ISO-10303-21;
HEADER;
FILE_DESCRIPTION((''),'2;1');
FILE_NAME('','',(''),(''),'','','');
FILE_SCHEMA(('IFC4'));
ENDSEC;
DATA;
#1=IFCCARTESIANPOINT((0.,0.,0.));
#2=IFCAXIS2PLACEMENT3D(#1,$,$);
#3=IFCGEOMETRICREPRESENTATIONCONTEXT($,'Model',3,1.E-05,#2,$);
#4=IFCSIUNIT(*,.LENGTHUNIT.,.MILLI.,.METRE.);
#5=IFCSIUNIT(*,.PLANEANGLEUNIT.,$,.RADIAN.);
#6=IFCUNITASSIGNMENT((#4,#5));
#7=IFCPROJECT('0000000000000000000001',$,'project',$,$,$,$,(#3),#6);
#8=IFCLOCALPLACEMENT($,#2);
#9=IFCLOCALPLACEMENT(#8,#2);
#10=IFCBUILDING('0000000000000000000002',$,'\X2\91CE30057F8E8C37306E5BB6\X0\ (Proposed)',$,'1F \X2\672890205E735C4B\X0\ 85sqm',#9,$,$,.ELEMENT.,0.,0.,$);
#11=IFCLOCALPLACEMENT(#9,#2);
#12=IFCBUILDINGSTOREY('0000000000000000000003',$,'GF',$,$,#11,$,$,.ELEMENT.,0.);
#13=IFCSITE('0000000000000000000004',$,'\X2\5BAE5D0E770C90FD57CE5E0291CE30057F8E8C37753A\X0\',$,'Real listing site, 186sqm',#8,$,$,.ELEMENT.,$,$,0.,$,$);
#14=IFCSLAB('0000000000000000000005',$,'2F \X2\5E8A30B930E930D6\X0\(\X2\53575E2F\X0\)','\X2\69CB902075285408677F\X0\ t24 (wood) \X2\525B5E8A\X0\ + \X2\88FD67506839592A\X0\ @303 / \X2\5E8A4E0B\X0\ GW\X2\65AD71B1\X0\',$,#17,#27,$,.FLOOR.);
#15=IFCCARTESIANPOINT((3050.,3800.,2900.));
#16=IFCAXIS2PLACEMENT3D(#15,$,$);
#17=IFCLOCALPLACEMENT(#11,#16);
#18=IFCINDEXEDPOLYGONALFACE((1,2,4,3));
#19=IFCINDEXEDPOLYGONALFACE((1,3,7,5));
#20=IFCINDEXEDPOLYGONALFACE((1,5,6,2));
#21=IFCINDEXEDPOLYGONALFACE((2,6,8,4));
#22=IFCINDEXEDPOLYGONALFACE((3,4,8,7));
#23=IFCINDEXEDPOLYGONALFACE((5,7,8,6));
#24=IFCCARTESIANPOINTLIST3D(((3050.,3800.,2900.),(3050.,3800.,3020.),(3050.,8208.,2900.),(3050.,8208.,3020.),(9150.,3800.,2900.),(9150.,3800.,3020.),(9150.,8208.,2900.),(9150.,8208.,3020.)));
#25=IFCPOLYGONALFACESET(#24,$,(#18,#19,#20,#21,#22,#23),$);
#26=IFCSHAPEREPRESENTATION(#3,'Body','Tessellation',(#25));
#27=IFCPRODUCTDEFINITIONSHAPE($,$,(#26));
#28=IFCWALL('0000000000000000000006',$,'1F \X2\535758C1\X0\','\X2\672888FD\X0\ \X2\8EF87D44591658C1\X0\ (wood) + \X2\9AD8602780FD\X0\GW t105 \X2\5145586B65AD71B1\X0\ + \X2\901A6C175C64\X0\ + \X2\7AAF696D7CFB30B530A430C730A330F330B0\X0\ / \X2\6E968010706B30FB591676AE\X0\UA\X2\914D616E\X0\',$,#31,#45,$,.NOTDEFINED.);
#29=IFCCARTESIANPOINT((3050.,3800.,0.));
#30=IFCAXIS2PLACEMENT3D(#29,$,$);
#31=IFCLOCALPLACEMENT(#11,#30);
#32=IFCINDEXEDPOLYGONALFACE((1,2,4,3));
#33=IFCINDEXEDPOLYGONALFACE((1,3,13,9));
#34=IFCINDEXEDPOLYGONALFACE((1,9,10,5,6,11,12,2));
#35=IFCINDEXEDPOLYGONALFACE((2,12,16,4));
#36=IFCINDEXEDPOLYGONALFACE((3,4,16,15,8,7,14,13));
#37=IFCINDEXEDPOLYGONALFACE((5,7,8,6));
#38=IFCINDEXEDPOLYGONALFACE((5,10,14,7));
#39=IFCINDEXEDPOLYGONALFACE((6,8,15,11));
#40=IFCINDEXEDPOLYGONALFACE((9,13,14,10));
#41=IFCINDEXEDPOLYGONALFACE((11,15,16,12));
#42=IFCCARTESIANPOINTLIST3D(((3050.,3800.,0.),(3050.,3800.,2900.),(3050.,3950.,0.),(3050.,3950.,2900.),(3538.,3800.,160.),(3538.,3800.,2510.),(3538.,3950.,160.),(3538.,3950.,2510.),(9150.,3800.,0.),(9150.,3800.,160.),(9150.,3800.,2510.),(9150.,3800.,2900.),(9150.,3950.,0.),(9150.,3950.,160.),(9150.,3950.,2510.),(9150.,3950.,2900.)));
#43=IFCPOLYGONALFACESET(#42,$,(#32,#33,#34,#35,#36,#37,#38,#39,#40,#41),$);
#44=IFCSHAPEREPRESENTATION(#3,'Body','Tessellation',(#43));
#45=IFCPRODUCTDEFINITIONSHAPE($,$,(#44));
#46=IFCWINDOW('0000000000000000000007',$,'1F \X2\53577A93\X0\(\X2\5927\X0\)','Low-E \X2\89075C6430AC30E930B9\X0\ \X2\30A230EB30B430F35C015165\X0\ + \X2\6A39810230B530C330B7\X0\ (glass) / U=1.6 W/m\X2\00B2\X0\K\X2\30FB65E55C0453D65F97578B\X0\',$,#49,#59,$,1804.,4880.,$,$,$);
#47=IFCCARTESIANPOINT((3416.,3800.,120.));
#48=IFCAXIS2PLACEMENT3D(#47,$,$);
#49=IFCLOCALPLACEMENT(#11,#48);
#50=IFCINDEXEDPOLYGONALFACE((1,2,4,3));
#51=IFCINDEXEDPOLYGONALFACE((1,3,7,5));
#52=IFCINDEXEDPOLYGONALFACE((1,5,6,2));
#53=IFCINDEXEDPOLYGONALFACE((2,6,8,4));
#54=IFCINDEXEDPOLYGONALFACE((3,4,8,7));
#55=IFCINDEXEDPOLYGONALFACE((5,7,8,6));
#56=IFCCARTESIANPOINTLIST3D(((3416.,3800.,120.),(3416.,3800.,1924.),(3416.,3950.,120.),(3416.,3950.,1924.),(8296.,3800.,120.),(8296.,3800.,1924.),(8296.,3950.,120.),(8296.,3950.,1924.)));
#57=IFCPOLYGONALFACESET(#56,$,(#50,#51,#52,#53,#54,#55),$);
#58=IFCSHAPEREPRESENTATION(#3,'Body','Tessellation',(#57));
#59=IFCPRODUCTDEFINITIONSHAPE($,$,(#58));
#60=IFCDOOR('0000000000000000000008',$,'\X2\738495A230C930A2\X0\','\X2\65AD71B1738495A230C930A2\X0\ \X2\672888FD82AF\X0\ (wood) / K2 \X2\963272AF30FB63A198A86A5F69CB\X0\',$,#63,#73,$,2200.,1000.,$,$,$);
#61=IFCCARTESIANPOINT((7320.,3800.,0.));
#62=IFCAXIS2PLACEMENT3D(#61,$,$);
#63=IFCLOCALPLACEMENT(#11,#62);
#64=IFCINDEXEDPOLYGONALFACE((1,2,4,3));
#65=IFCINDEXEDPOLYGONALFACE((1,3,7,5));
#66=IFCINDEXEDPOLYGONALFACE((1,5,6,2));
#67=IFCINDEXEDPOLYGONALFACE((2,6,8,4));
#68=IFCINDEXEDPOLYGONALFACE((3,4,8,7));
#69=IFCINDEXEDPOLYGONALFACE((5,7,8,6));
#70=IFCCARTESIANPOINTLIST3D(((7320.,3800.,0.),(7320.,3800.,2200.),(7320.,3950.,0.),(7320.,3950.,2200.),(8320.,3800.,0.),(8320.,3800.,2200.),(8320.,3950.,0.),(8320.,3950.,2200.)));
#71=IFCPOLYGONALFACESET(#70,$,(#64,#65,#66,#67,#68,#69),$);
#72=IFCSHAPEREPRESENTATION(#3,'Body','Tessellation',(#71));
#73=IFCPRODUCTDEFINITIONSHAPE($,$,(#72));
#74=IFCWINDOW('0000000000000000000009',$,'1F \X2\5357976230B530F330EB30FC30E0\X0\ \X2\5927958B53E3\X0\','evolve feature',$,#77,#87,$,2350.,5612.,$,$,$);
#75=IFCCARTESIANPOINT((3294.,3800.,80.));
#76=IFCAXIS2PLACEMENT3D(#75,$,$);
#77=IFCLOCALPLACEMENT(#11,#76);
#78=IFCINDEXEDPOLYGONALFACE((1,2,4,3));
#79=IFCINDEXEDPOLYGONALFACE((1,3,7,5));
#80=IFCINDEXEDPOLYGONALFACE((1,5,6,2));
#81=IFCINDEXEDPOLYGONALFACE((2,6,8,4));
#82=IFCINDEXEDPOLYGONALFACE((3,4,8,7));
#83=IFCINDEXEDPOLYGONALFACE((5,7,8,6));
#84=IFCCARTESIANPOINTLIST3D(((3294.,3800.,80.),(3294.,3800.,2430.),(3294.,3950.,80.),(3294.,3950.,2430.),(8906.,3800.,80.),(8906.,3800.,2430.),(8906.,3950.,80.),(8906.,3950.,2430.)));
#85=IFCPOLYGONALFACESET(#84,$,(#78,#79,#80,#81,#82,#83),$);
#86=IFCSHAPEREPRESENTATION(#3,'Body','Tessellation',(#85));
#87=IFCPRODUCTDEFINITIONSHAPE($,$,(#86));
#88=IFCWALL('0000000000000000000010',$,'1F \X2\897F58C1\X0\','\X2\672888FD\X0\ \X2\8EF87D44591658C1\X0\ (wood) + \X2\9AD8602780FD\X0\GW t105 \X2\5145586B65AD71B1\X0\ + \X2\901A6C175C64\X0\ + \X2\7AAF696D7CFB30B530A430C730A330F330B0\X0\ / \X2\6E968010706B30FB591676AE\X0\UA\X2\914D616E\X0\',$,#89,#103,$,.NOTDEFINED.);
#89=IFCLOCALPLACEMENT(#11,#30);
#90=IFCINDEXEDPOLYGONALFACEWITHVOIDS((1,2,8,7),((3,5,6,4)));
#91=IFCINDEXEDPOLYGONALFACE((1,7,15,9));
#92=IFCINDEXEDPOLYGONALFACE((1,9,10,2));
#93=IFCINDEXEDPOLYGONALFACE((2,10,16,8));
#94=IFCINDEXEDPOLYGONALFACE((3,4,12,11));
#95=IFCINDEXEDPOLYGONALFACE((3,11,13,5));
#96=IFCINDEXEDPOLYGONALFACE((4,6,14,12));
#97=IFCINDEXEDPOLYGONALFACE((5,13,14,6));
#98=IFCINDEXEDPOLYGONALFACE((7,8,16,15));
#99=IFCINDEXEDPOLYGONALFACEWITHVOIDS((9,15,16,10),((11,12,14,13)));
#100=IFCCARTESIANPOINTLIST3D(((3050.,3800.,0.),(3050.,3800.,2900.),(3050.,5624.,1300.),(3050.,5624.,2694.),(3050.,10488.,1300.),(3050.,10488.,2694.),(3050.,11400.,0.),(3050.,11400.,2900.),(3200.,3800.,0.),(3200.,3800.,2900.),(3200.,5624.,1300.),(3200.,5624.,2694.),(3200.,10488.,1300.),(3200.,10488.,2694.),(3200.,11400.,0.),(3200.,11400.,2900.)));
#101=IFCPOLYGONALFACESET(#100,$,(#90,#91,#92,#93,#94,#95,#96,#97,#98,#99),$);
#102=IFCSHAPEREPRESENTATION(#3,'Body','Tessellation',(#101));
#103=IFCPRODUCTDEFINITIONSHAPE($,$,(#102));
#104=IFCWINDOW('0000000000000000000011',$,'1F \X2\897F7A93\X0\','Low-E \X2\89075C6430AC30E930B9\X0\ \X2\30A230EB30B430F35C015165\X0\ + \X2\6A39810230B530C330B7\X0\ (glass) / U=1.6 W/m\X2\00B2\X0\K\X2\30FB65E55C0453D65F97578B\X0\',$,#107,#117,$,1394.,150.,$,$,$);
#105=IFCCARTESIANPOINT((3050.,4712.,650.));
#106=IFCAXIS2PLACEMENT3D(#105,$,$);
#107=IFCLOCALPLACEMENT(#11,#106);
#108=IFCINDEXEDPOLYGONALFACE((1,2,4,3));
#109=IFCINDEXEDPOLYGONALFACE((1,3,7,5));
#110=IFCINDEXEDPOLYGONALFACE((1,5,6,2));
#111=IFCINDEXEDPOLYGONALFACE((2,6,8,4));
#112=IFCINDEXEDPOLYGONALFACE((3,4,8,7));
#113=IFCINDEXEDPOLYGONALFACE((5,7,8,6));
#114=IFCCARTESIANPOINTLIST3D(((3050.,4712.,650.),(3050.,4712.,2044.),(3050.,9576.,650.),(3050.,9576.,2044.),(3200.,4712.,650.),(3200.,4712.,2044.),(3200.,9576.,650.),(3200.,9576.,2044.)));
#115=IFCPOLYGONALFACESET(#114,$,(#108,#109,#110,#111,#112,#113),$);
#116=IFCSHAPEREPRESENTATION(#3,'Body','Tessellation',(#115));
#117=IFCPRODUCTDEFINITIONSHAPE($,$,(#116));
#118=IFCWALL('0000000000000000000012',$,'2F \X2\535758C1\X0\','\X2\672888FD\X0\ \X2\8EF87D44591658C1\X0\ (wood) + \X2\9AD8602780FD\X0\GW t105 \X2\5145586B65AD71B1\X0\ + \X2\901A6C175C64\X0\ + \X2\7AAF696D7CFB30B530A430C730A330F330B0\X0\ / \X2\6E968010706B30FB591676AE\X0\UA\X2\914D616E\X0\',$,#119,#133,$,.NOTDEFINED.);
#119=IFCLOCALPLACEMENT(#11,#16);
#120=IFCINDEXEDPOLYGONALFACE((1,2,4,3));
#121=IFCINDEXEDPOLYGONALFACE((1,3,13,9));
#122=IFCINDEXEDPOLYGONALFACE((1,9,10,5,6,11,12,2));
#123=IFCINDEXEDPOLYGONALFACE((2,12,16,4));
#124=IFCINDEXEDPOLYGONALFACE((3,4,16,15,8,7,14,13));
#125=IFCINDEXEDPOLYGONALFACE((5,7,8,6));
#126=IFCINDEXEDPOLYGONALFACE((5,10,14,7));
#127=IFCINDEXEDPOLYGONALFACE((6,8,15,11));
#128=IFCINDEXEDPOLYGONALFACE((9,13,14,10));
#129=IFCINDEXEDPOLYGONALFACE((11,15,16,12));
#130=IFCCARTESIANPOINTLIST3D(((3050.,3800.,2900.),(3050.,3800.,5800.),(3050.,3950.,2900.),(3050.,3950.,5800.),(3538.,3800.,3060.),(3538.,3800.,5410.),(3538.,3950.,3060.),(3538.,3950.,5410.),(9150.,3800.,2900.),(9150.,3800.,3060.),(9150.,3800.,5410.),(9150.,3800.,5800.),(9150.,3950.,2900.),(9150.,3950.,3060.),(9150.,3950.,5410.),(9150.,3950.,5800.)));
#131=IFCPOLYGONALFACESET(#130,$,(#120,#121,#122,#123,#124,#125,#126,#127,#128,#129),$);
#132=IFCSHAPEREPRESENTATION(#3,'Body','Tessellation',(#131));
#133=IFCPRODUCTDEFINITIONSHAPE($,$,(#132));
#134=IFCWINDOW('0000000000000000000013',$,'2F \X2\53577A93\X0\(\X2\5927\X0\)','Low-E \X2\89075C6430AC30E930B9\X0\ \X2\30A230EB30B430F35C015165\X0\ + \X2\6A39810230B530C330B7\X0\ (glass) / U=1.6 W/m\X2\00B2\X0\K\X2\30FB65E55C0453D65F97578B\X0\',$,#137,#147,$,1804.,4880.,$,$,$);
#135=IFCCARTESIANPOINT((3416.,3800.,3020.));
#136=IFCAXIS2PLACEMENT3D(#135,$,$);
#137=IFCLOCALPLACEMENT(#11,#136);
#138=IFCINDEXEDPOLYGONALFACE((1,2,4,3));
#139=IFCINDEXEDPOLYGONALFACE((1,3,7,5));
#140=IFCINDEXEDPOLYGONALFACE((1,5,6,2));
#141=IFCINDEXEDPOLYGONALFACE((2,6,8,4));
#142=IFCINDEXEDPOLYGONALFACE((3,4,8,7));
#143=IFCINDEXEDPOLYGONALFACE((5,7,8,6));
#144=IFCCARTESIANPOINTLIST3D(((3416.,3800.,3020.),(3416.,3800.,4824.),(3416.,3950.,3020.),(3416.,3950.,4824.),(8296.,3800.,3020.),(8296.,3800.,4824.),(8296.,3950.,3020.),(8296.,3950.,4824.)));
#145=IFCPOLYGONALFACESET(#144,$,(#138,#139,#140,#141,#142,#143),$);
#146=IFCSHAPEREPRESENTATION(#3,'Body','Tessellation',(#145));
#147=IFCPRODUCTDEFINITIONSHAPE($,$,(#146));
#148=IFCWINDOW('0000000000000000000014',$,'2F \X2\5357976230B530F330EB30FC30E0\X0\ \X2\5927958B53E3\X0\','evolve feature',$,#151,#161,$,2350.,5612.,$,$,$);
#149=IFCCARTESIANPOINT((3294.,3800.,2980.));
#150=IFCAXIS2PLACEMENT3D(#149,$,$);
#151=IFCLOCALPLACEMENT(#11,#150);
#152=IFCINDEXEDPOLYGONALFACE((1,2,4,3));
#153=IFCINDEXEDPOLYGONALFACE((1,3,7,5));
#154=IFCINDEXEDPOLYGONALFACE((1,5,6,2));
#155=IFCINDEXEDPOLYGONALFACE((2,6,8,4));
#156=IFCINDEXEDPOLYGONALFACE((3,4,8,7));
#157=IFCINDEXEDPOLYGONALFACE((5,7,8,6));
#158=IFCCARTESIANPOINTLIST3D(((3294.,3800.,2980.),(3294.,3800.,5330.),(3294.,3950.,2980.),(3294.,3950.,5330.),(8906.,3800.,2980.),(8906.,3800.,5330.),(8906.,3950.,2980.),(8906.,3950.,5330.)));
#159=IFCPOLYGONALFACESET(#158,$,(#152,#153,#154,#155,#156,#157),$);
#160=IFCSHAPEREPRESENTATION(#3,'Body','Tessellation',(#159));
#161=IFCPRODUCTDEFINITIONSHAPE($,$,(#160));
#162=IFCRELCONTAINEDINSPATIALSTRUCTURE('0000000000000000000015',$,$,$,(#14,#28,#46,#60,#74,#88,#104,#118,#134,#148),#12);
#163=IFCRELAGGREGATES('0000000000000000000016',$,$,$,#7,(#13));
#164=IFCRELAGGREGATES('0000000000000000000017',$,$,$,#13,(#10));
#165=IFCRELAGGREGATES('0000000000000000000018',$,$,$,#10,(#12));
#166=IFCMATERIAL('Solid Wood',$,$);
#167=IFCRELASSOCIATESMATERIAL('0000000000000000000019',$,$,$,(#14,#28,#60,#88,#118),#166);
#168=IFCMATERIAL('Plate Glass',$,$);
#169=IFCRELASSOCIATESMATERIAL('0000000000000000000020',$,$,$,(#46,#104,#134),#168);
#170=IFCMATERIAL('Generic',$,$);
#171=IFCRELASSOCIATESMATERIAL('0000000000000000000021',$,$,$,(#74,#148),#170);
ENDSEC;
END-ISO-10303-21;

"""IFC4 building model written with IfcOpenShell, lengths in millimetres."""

from ifc_helpers import new_model, si_unit, frame, frame_2d, origin, place, context, project, spatial, rectangle, extrude, material, element, fill, save


model = new_model("IFC4")

# Units and contexts
model_context = context("Model", 3, precision=1e-05, world=origin())
ifc_project = project(units=[si_unit("LENGTHUNIT", "METRE", prefix="MILLI"), si_unit("PLANEANGLEUNIT", "RADIAN")], contexts=[model_context])

# Site, building, storey
site_placement = place(None, origin())
site = spatial("IfcSite", under=ifc_project, at=site_placement, Name="宮崎県都城市野々美谷町", ObjectType="Real listing site, 186sqm", CompositionType="ELEMENT", RefElevation=0.0)
building_placement = place(site_placement, origin())
building = spatial("IfcBuilding", under=site, at=building_placement, Name="野々美谷の家 (Proposed)", ObjectType="1F 木造平屋 85sqm", CompositionType="ELEMENT", ElevationOfRefHeight=0.0, ElevationOfTerrain=0.0)
storey_placement = place(building_placement, origin())
storey = spatial("IfcBuildingStorey", under=building, at=storey_placement, Name="GF", CompositionType="ELEMENT", Elevation=0.0)

# Slab
ifc_material_1 = material(Name="Solid Wood")
slab_1_placement = place(storey_placement, frame((3050.0, 3800.0, 2900.0)))
element("IfcSlab", 1, at=slab_1_placement, inside=storey, material=ifc_material_1, Name="2F 床スラブ(南帯)", Description="構造用合板 t24 (wood) 剛床 + 製材根太 @303 / 床下 GW断熱", PredefinedType="FLOOR", context=model_context, shape_type="SweptSolid", body=[
    extrude(rectangle(XDim=6100.0, YDim=4408.0, at=frame_2d((3050.0, 2204.0))), frame((3050.0, 3800.0, 2900.0)), (0.0, 0.0, 1.0), 120.0),
])
ifc_material_2 = material(Name="Generic")

# Wall, openings, windows, door
wall_1_placement = place(storey_placement, frame((3050.0, 3800.0, 0.0)))
wall_1 = element("IfcWall", 2, at=wall_1_placement, inside=storey, material=ifc_material_1, Name="1F 南壁", Description="木製 軸組外壁 (wood) + 高性能GW t105 充填断熱 + 通気層 + 窯業系サイディング / 準耐火・外皮UA配慮", PredefinedType="NOTDEFINED", context=model_context, shape_type="SweptSolid", body=[
    extrude(rectangle(XDim=6100.0, YDim=150.0, at=frame_2d((3050.0, 75.0))), frame((3050.0, 3800.0, 0.0)), (0.0, 0.0, 1.0), 2900.0),
])
opening_1_placement = place(storey_placement, frame((3416.0, 3800.0, 120.0)))
opening_1 = element("IfcOpeningElement", 3, at=opening_1_placement, cuts=wall_1, PredefinedType="NOTDEFINED", context=model_context, shape_type="SweptSolid", body=[
    extrude(rectangle(XDim=4880.0, YDim=150.0, at=frame_2d((2440.0, 75.0))), frame((3416.0, 3800.0, 120.0)), (0.0, 0.0, 1.0), 1804.0),
])
opening_2_placement = place(storey_placement, frame((7320.0, 3800.0, 0.0)))
opening_2 = element("IfcOpeningElement", 4, at=opening_2_placement, cuts=wall_1, PredefinedType="NOTDEFINED", context=model_context, shape_type="SweptSolid", body=[
    extrude(rectangle(XDim=1000.0, YDim=150.0, at=frame_2d((500.0, 75.0))), frame((7320.0, 3800.0, 0.0)), (0.0, 0.0, 1.0), 2200.0),
])
opening_3_placement = place(storey_placement, frame((3294.0, 3800.0, 80.0)))
opening_3 = element("IfcOpeningElement", 5, at=opening_3_placement, cuts=wall_1, PredefinedType="NOTDEFINED", context=model_context, shape_type="SweptSolid", body=[
    extrude(rectangle(XDim=5612.0, YDim=150.0, at=frame_2d((2806.0, 75.0))), frame((3294.0, 3800.0, 80.0)), (0.0, 0.0, 1.0), 2350.0),
])
ifc_material_3 = material(Name="Plate Glass")
window_1_placement = place(storey_placement, frame((3416.0, 3800.0, 120.0)))
window_1 = element("IfcWindow", 6, at=window_1_placement, inside=storey, material=ifc_material_3, Name="1F 南窓(大)", Description="Low-E 複層ガラス アルゴン封入 + 樹脂サッシ (glass) / U=1.6 W/m²K・日射取得型", OverallHeight=1804.0, OverallWidth=4880.0, context=model_context, shape_type="SweptSolid", body=[
    extrude(rectangle(XDim=4880.0, YDim=150.0, at=frame_2d((2440.0, 75.0))), frame((3416.0, 3800.0, 120.0)), (0.0, 0.0, 1.0), 1804.0),
])
fill(opening_1, window_1)
door_placement = place(storey_placement, frame((7320.0, 3800.0, 0.0)))
door = element("IfcDoor", 7, at=door_placement, inside=storey, material=ifc_material_1, Name="玄関ドア", Description="断熱玄関ドア 木製芯 (wood) / K2 防犯・採風機構", OverallHeight=2200.0, OverallWidth=1000.0, context=model_context, shape_type="SweptSolid", body=[
    extrude(rectangle(XDim=1000.0, YDim=150.0, at=frame_2d((500.0, 75.0))), frame((7320.0, 3800.0, 0.0)), (0.0, 0.0, 1.0), 2200.0),
])
fill(opening_2, door)
window_2_placement = place(storey_placement, frame((3294.0, 3800.0, 80.0)))
window_2 = element("IfcWindow", 8, at=window_2_placement, inside=storey, material=ifc_material_2, Name="1F 南面サンルーム 大開口", Description="evolve feature", OverallHeight=2350.0, OverallWidth=5612.0, context=model_context, shape_type="SweptSolid", body=[
    extrude(rectangle(XDim=5612.0, YDim=150.0, at=frame_2d((2806.0, 75.0))), frame((3294.0, 3800.0, 80.0)), (0.0, 0.0, 1.0), 2350.0),
])
fill(opening_3, window_2)

# Wall, opening, window
wall_2_placement = place(storey_placement, frame((3050.0, 3800.0, 0.0)))
wall_2 = element("IfcWall", 9, at=wall_2_placement, inside=storey, material=ifc_material_1, Name="1F 西壁", Description="木製 軸組外壁 (wood) + 高性能GW t105 充填断熱 + 通気層 + 窯業系サイディング / 準耐火・外皮UA配慮", PredefinedType="NOTDEFINED", context=model_context, shape_type="SweptSolid", body=[
    extrude(rectangle(XDim=150.0, YDim=7600.0, at=frame_2d((75.0, 3800.0))), frame((3050.0, 3800.0, 0.0)), (0.0, 0.0, 1.0), 2900.0),
])
opening_4_placement = place(storey_placement, frame((3050.0, 4712.0, 650.0)))
opening_4 = element("IfcOpeningElement", 10, at=opening_4_placement, cuts=wall_2, PredefinedType="NOTDEFINED", context=model_context, shape_type="SweptSolid", body=[
    extrude(rectangle(XDim=150.0, YDim=4864.0, at=frame_2d((75.0, 2432.0))), frame((3050.0, 4712.0, 650.0)), (0.0, 0.0, 1.0), 1394.0),
])
window_3_placement = place(storey_placement, frame((3050.0, 4712.0, 650.0)))
window_3 = element("IfcWindow", 11, at=window_3_placement, inside=storey, material=ifc_material_3, Name="1F 西窓", Description="Low-E 複層ガラス アルゴン封入 + 樹脂サッシ (glass) / U=1.6 W/m²K・日射取得型", OverallHeight=1394.0, OverallWidth=150.0, context=model_context, shape_type="SweptSolid", body=[
    extrude(rectangle(XDim=150.0, YDim=4864.0, at=frame_2d((75.0, 2432.0))), frame((3050.0, 4712.0, 650.0)), (0.0, 0.0, 1.0), 1394.0),
])
fill(opening_4, window_3)

# Wall, openings, windows
wall_3_placement = place(storey_placement, frame((3050.0, 3800.0, 2900.0)))
wall_3 = element("IfcWall", 12, at=wall_3_placement, inside=storey, material=ifc_material_1, Name="2F 南壁", Description="木製 軸組外壁 (wood) + 高性能GW t105 充填断熱 + 通気層 + 窯業系サイディング / 準耐火・外皮UA配慮", PredefinedType="NOTDEFINED", context=model_context, shape_type="SweptSolid", body=[
    extrude(rectangle(XDim=6100.0, YDim=150.0, at=frame_2d((3050.0, 75.0))), frame((3050.0, 3800.0, 2900.0)), (0.0, 0.0, 1.0), 2900.0),
])
opening_5_placement = place(storey_placement, frame((3416.0, 3800.0, 3020.0)))
opening_5 = element("IfcOpeningElement", 13, at=opening_5_placement, cuts=wall_3, PredefinedType="NOTDEFINED", context=model_context, shape_type="SweptSolid", body=[
    extrude(rectangle(XDim=4880.0, YDim=150.0, at=frame_2d((2440.0, 75.0))), frame((3416.0, 3800.0, 3020.0)), (0.0, 0.0, 1.0), 1804.0),
])
opening_6_placement = place(storey_placement, frame((3294.0, 3800.0, 2980.0)))
opening_6 = element("IfcOpeningElement", 14, at=opening_6_placement, cuts=wall_3, PredefinedType="NOTDEFINED", context=model_context, shape_type="SweptSolid", body=[
    extrude(rectangle(XDim=5612.0, YDim=150.0, at=frame_2d((2806.0, 75.0))), frame((3294.0, 3800.0, 2980.0)), (0.0, 0.0, 1.0), 2350.0),
])
window_4_placement = place(storey_placement, frame((3416.0, 3800.0, 3020.0)))
window_4 = element("IfcWindow", 15, at=window_4_placement, inside=storey, material=ifc_material_3, Name="2F 南窓(大)", Description="Low-E 複層ガラス アルゴン封入 + 樹脂サッシ (glass) / U=1.6 W/m²K・日射取得型", OverallHeight=1804.0, OverallWidth=4880.0, context=model_context, shape_type="SweptSolid", body=[
    extrude(rectangle(XDim=4880.0, YDim=150.0, at=frame_2d((2440.0, 75.0))), frame((3416.0, 3800.0, 3020.0)), (0.0, 0.0, 1.0), 1804.0),
])
fill(opening_5, window_4)
window_5_placement = place(storey_placement, frame((3294.0, 3800.0, 2980.0)))
window_5 = element("IfcWindow", 16, at=window_5_placement, inside=storey, material=ifc_material_2, Name="2F 南面サンルーム 大開口", Description="evolve feature", OverallHeight=2350.0, OverallWidth=5612.0, context=model_context, shape_type="SweptSolid", body=[
    extrude(rectangle(XDim=5612.0, YDim=150.0, at=frame_2d((2806.0, 75.0))), frame((3294.0, 3800.0, 2980.0)), (0.0, 0.0, 1.0), 2350.0),
])
fill(opening_6, window_5)

save(model, "model.ifc")
